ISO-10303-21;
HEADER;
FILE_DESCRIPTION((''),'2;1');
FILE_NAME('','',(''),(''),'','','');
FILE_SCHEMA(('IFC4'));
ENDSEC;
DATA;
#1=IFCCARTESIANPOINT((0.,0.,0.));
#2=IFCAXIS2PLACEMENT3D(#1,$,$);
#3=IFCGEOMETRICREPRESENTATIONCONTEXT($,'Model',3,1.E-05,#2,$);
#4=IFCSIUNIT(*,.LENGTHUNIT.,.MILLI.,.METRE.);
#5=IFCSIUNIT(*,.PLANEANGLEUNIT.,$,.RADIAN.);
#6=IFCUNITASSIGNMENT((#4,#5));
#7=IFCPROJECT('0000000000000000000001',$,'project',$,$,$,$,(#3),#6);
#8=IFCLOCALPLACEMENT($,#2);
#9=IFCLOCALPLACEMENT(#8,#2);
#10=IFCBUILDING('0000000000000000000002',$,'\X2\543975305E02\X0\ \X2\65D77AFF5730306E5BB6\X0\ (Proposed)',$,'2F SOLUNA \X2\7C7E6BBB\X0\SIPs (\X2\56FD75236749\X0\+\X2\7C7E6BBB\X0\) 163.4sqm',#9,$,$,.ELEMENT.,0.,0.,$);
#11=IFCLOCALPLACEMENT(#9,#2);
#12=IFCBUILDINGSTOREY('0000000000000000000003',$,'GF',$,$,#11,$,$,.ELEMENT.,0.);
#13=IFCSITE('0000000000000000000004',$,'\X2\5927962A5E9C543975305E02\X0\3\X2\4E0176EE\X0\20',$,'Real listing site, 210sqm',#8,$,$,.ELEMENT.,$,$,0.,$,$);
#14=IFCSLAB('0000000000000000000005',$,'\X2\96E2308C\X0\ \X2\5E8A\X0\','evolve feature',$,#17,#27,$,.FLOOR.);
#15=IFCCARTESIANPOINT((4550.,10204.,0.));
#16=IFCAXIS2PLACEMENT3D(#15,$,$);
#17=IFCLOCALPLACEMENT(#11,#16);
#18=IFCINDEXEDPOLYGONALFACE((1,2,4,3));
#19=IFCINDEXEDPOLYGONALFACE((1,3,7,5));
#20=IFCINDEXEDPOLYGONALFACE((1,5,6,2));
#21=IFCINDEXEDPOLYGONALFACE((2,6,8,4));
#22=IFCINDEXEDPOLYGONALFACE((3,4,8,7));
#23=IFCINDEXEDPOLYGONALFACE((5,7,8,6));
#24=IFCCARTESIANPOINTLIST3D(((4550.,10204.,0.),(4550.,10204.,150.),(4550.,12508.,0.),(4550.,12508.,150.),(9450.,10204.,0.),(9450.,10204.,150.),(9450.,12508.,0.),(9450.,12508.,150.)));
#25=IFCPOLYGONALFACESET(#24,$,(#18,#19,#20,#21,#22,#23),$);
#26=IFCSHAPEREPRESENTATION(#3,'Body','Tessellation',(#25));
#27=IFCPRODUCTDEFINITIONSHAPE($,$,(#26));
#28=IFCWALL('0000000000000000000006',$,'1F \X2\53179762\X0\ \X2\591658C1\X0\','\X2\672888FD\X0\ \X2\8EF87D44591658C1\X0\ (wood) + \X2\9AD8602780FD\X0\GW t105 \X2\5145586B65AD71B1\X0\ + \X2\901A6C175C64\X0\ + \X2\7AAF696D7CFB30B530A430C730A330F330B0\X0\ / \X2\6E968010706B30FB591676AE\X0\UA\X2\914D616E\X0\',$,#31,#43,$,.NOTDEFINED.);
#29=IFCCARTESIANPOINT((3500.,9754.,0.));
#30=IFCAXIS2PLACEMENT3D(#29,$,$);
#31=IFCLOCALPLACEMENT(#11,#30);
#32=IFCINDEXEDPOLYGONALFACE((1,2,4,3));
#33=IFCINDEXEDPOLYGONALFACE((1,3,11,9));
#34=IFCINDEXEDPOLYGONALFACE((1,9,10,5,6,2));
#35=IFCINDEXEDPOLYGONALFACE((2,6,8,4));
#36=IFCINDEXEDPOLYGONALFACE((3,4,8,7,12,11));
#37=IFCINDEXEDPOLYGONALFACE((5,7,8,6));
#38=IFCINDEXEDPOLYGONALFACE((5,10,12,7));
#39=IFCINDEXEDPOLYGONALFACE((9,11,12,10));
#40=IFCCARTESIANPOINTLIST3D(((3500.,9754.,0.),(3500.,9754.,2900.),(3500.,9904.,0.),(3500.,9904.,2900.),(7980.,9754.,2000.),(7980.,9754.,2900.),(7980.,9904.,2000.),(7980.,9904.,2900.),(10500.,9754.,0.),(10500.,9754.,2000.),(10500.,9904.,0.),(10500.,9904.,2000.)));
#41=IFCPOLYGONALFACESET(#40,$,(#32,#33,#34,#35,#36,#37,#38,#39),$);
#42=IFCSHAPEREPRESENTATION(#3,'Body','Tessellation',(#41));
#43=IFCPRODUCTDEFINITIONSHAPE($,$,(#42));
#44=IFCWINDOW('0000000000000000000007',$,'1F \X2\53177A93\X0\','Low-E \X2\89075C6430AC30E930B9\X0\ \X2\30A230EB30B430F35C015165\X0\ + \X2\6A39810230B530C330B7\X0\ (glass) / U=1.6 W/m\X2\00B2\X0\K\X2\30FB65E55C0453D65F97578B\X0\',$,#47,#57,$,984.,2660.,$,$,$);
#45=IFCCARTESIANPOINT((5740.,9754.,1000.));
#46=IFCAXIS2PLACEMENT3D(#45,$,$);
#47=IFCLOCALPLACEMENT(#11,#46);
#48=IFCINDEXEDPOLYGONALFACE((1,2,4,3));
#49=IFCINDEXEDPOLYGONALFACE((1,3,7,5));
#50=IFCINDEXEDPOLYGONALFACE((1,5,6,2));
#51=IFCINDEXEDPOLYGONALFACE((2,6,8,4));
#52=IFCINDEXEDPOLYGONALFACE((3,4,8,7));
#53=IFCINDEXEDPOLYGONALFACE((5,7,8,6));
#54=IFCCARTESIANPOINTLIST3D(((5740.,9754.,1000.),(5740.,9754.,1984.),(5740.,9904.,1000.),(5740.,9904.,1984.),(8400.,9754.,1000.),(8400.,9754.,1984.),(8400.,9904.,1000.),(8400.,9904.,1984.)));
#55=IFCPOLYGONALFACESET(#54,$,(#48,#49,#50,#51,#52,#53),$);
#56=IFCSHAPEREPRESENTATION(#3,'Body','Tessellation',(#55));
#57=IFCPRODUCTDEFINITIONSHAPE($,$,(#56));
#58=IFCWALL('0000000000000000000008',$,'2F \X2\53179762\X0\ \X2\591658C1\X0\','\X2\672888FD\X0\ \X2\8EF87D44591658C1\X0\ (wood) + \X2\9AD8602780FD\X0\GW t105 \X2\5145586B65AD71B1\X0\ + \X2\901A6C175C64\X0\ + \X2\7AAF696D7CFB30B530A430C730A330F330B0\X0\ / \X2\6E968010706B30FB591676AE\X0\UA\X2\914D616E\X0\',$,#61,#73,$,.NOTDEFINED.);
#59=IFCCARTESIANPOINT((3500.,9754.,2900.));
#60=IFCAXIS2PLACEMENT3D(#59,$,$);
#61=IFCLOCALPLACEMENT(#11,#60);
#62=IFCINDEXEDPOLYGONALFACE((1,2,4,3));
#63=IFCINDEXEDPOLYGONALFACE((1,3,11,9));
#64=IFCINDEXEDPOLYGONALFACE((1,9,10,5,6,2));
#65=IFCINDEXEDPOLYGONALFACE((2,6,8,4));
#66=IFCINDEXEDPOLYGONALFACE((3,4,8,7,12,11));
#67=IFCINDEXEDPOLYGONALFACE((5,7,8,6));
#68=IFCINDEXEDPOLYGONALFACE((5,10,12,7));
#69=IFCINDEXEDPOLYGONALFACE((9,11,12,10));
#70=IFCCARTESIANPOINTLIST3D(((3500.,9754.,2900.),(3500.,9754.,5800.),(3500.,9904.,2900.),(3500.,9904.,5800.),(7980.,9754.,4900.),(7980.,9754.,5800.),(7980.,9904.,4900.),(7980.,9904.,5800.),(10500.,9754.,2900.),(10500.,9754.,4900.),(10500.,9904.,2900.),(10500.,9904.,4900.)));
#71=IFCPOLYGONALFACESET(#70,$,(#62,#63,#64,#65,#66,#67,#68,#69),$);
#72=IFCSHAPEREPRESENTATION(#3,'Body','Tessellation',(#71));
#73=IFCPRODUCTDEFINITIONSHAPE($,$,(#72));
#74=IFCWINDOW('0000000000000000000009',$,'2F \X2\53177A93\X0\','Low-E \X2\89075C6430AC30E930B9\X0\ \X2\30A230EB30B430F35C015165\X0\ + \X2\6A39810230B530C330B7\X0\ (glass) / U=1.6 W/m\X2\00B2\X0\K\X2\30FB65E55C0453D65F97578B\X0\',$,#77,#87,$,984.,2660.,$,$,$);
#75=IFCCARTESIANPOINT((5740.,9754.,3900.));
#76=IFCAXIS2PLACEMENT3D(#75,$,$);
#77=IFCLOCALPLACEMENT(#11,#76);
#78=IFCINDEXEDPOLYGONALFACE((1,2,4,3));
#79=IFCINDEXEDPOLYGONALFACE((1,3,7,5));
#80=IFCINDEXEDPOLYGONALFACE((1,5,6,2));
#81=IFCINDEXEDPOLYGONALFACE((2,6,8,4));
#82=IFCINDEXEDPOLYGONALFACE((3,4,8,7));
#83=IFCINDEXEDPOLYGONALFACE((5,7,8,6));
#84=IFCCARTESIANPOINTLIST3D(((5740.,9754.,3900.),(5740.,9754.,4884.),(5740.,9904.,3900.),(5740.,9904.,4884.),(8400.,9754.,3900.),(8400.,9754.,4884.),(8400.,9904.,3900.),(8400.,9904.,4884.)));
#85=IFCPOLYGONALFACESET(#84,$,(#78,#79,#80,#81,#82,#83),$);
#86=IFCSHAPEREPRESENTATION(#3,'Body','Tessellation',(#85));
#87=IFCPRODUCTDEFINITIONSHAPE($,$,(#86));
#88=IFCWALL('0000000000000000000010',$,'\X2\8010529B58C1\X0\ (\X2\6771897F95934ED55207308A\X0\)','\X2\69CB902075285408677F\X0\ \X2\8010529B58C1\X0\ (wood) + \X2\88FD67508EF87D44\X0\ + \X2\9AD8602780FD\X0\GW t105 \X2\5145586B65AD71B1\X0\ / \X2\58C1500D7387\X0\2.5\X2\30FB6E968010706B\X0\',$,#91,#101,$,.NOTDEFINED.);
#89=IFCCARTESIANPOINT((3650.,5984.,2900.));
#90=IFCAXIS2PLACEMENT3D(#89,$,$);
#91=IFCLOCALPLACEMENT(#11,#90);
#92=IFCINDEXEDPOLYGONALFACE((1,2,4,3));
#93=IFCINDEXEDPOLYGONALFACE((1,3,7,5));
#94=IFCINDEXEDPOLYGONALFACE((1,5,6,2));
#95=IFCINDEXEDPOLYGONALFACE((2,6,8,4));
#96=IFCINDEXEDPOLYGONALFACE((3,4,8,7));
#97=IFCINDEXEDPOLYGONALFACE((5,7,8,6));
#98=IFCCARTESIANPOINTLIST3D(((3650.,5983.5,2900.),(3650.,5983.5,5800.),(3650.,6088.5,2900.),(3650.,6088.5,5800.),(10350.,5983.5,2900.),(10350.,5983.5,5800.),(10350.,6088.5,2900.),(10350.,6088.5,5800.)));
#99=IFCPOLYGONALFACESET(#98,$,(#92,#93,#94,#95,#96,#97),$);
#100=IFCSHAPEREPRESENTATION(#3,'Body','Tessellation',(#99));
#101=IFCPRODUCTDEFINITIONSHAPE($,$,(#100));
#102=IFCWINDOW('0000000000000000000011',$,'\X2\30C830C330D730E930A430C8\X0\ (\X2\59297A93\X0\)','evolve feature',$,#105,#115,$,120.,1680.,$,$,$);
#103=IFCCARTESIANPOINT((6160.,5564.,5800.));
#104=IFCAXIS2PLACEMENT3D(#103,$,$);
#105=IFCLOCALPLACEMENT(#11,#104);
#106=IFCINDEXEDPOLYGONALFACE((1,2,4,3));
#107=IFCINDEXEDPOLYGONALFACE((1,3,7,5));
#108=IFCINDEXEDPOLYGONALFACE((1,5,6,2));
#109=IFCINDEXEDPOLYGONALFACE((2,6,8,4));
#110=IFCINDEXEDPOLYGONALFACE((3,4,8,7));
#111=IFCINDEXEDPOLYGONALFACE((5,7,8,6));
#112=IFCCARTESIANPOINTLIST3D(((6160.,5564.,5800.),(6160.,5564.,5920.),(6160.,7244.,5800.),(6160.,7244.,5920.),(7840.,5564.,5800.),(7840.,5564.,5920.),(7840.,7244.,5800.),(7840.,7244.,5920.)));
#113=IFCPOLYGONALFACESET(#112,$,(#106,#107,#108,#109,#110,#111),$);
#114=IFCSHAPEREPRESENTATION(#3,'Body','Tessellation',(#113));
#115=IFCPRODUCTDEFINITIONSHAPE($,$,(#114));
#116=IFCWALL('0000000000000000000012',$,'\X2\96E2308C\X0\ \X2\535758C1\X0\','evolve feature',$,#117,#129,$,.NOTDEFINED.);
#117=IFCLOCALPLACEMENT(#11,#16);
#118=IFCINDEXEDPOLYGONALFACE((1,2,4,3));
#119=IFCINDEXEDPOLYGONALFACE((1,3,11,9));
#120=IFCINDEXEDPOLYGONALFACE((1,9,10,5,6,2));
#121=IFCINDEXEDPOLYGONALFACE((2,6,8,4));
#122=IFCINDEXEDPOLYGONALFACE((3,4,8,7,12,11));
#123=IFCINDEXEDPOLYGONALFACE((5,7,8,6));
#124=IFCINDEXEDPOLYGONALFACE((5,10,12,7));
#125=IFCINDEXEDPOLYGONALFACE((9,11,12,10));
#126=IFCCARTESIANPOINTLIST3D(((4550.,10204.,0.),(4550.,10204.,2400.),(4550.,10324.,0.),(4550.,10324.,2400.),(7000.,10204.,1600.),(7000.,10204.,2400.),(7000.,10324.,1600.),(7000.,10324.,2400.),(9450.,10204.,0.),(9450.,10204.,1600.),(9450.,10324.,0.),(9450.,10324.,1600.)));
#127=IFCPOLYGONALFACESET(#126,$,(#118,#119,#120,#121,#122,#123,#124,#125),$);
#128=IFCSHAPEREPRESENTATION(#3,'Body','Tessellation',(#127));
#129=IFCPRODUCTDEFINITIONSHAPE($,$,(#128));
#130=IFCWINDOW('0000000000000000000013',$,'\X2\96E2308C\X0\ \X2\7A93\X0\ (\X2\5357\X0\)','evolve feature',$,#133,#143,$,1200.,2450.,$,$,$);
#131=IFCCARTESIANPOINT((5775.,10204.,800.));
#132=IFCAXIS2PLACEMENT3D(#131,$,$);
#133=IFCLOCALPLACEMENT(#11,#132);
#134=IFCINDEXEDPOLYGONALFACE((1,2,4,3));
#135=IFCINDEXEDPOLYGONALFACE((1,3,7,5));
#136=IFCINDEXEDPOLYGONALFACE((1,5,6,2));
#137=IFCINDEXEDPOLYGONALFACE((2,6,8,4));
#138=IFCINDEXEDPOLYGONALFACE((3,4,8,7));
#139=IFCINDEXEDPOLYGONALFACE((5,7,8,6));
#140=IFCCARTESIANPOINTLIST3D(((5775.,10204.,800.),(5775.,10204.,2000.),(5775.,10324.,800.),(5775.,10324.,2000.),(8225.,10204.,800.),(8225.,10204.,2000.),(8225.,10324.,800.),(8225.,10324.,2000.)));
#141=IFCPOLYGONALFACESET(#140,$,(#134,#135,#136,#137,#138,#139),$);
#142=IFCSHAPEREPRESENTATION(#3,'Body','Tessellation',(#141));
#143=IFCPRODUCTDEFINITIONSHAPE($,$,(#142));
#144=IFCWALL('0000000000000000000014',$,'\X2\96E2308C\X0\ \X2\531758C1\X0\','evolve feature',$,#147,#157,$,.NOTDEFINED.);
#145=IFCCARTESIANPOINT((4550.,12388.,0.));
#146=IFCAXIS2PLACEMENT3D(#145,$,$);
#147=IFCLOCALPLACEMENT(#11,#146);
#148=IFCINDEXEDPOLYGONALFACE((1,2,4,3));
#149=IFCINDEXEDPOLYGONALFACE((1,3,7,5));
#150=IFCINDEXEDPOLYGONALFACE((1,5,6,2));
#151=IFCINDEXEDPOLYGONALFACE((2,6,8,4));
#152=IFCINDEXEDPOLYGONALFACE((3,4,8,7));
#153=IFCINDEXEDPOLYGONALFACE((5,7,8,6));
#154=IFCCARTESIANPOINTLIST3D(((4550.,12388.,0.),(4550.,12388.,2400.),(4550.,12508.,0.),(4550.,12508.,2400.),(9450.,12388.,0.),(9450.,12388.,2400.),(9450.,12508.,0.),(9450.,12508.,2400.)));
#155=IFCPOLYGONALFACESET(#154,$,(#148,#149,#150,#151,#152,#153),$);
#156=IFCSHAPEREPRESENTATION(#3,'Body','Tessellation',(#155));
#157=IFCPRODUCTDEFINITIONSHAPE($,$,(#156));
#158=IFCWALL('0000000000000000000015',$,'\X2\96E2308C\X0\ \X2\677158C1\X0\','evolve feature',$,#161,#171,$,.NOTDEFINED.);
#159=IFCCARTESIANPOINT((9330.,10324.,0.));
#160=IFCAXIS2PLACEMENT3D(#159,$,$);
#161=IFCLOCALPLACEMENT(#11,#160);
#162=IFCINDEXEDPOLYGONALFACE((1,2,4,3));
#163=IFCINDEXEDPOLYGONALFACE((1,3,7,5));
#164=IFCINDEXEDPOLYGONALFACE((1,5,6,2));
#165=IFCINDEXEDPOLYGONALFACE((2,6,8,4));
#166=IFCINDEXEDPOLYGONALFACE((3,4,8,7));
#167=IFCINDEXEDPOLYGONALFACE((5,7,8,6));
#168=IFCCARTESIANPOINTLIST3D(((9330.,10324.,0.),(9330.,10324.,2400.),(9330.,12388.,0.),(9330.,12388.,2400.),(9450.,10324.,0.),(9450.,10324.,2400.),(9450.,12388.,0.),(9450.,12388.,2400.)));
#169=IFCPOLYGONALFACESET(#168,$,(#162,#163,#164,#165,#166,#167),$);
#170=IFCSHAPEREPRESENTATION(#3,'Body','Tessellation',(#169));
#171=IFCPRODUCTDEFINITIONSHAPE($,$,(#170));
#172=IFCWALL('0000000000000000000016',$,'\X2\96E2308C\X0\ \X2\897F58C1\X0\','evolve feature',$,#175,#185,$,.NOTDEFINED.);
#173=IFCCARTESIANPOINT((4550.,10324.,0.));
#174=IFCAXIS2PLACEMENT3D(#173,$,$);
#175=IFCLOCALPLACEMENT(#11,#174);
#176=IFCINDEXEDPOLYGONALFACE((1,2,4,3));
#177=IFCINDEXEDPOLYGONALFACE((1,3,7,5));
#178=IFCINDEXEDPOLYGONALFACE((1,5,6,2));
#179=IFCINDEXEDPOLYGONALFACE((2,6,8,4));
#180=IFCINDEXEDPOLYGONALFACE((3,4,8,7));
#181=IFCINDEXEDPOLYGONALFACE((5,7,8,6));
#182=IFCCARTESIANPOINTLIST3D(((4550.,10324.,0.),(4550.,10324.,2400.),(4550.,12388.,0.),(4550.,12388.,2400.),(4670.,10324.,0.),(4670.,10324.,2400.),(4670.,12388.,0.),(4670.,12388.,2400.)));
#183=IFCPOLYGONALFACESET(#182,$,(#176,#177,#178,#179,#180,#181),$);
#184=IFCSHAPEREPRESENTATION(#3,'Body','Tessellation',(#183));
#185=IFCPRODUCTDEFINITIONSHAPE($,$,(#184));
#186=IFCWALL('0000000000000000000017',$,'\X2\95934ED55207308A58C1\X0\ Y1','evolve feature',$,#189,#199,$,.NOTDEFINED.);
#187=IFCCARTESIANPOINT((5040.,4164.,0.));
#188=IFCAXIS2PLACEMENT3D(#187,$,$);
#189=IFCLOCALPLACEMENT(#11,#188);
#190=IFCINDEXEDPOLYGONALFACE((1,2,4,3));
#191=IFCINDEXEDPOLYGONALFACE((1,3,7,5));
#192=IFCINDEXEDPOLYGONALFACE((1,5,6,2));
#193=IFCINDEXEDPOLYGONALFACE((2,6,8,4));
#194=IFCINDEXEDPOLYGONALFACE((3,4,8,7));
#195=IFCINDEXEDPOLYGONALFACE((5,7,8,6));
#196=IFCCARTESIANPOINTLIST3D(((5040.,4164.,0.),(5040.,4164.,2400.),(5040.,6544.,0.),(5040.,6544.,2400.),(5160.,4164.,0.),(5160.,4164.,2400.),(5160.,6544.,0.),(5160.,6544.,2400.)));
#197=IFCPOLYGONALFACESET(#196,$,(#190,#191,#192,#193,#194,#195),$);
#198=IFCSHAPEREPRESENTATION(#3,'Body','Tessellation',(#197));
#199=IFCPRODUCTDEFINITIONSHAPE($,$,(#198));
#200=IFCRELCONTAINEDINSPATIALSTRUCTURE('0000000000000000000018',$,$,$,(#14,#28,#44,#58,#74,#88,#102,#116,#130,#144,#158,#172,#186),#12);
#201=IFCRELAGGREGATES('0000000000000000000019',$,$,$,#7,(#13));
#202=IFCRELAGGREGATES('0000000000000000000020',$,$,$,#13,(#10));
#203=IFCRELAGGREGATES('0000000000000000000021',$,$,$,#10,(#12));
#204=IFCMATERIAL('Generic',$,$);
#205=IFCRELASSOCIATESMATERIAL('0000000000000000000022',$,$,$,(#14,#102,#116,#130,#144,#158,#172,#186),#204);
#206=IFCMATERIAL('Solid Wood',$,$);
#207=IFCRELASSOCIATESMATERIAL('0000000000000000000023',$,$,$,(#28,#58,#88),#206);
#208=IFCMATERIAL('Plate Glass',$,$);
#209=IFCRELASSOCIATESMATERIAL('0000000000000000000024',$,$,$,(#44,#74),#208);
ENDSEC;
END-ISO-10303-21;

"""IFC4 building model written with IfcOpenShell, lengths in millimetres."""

from ifc_helpers import new_model, si_unit, frame, frame_2d, origin, place, context, project, spatial, rectangle, extrude, material, element, fill, save


model = new_model("IFC4")

# Units and contexts
model_context = context("Model", 3, precision=1e-05, world=origin())
ifc_project = project(units=[si_unit("LENGTHUNIT", "METRE", prefix="MILLI"), si_unit("PLANEANGLEUNIT", "RADIAN")], contexts=[model_context])

# Site, building, storey
site_placement = place(None, origin())
site = spatial("IfcSite", under=ifc_project, at=site_placement, Name="大阪府吹田市3丁目20", ObjectType="Real listing site, 210sqm", CompositionType="ELEMENT", RefElevation=0.0)
building_placement = place(site_placement, origin())
building = spatial("IfcBuilding", under=site, at=building_placement, Name="吹田市 旗竿地の家 (Proposed)", ObjectType="2F SOLUNA 籾殻SIPs (国産杉+籾殻) 163.4sqm", CompositionType="ELEMENT", ElevationOfRefHeight=0.0, ElevationOfTerrain=0.0)
storey_placement = place(building_placement, origin())
storey = spatial("IfcBuildingStorey", under=building, at=storey_placement, Name="GF", CompositionType="ELEMENT", Elevation=0.0)

# Slab
ifc_material_1 = material(Name="Generic")
slab_placement = place(storey_placement, frame((4550.0, 10204.0, 0.0)))
element("IfcSlab", 1, at=slab_placement, inside=storey, material=ifc_material_1, Name="離れ 床", Description="evolve feature", PredefinedType="FLOOR", context=model_context, shape_type="SweptSolid", body=[
    extrude(rectangle(XDim=4900.0, YDim=2304.0, at=frame_2d((2450.0, 1152.0))), frame((4550.0, 10204.0, 0.0)), (0.0, 0.0, 1.0), 150.0),
])

# Wall, opening, window
ifc_material_2 = material(Name="Solid Wood")
wall_1_placement = place(storey_placement, frame((3500.0, 9754.0, 0.0)))
wall_1 = element("IfcWall", 2, at=wall_1_placement, inside=storey, material=ifc_material_2, Name="1F 北面 外壁", Description="木製 軸組外壁 (wood) + 高性能GW t105 充填断熱 + 通気層 + 窯業系サイディング / 準耐火・外皮UA配慮", PredefinedType="NOTDEFINED", context=model_context, shape_type="SweptSolid", body=[
    extrude(rectangle(XDim=7000.0, YDim=150.0, at=frame_2d((3500.0, 75.0))), frame((3500.0, 9754.0, 0.0)), (0.0, 0.0, 1.0), 2900.0),
])
opening_1_placement = place(storey_placement, frame((5740.0, 9754.0, 1000.0)))
opening_1 = element("IfcOpeningElement", 3, at=opening_1_placement, cuts=wall_1, PredefinedType="NOTDEFINED", context=model_context, shape_type="SweptSolid", body=[
    extrude(rectangle(XDim=2660.0, YDim=150.0, at=frame_2d((1330.0, 75.0))), frame((5740.0, 9754.0, 1000.0)), (0.0, 0.0, 1.0), 984.0),
])
ifc_material_3 = material(Name="Plate Glass")
window_1_placement = place(storey_placement, frame((5740.0, 9754.0, 1000.0)))
window_1 = element("IfcWindow", 4, at=window_1_placement, inside=storey, material=ifc_material_3, Name="1F 北窓", Description="Low-E 複層ガラス アルゴン封入 + 樹脂サッシ (glass) / U=1.6 W/m²K・日射取得型", OverallHeight=984.0, OverallWidth=2660.0, context=model_context, shape_type="SweptSolid", body=[
    extrude(rectangle(XDim=2660.0, YDim=150.0, at=frame_2d((1330.0, 75.0))), frame((5740.0, 9754.0, 1000.0)), (0.0, 0.0, 1.0), 984.0),
])
fill(opening_1, window_1)

# Wall, opening, window
wall_2_placement = place(storey_placement, frame((3500.0, 9754.0, 2900.0)))
wall_2 = element("IfcWall", 5, at=wall_2_placement, inside=storey, material=ifc_material_2, Name="2F 北面 外壁", Description="木製 軸組外壁 (wood) + 高性能GW t105 充填断熱 + 通気層 + 窯業系サイディング / 準耐火・外皮UA配慮", PredefinedType="NOTDEFINED", context=model_context, shape_type="SweptSolid", body=[
    extrude(rectangle(XDim=7000.0, YDim=150.0, at=frame_2d((3500.0, 75.0))), frame((3500.0, 9754.0, 2900.0)), (0.0, 0.0, 1.0), 2900.0),
])
opening_2_placement = place(storey_placement, frame((5740.0, 9754.0, 3900.0)))
opening_2 = element("IfcOpeningElement", 6, at=opening_2_placement, cuts=wall_2, PredefinedType="NOTDEFINED", context=model_context, shape_type="SweptSolid", body=[
    extrude(rectangle(XDim=2660.0, YDim=150.0, at=frame_2d((1330.0, 75.0))), frame((5740.0, 9754.0, 3900.0)), (0.0, 0.0, 1.0), 984.0),
])
window_2_placement = place(storey_placement, frame((5740.0, 9754.0, 3900.0)))
window_2 = element("IfcWindow", 7, at=window_2_placement, inside=storey, material=ifc_material_3, Name="2F 北窓", Description="Low-E 複層ガラス アルゴン封入 + 樹脂サッシ (glass) / U=1.6 W/m²K・日射取得型", OverallHeight=984.0, OverallWidth=2660.0, context=model_context, shape_type="SweptSolid", body=[
    extrude(rectangle(XDim=2660.0, YDim=150.0, at=frame_2d((1330.0, 75.0))), frame((5740.0, 9754.0, 3900.0)), (0.0, 0.0, 1.0), 984.0),
])
fill(opening_2, window_2)

# Wall
wall_3_placement = place(storey_placement, frame((3650.0, 5984.0, 2900.0)))
element("IfcWall", 8, at=wall_3_placement, inside=storey, material=ifc_material_2, Name="耐力壁 (東西間仕切り)", Description="構造用合板 耐力壁 (wood) + 製材軸組 + 高性能GW t105 充填断熱 / 壁倍率2.5・準耐火", PredefinedType="NOTDEFINED", context=model_context, shape_type="SweptSolid", body=[
    extrude(rectangle(XDim=6700.0, YDim=105.0, at=frame_2d((3350.0, 52.0))), frame((3650.0, 5984.0, 2900.0)), (0.0, 0.0, 1.0), 2900.0),
])

# Window
window_3_placement = place(storey_placement, frame((6160.0, 5564.0, 5800.0)))
element("IfcWindow", 9, at=window_3_placement, inside=storey, material=ifc_material_1, Name="トップライト (天窓)", Description="evolve feature", OverallHeight=120.0, OverallWidth=1680.0, context=model_context, shape_type="SweptSolid", body=[
    extrude(rectangle(XDim=1680.0, YDim=1680.0, at=frame_2d((840.0, 840.0))), frame((6160.0, 5564.0, 5800.0)), (0.0, 0.0, 1.0), 120.0),
])

# Wall, opening, window
wall_4_placement = place(storey_placement, frame((4550.0, 10204.0, 0.0)))
wall_4 = element("IfcWall", 10, at=wall_4_placement, inside=storey, material=ifc_material_1, Name="離れ 南壁", Description="evolve feature", PredefinedType="NOTDEFINED", context=model_context, shape_type="SweptSolid", body=[
    extrude(rectangle(XDim=4900.0, YDim=120.0, at=frame_2d((2450.0, 60.0))), frame((4550.0, 10204.0, 0.0)), (0.0, 0.0, 1.0), 2400.0),
])
opening_3_placement = place(storey_placement, frame((5775.0, 10204.0, 800.0)))
opening_3 = element("IfcOpeningElement", 11, at=opening_3_placement, cuts=wall_4, PredefinedType="NOTDEFINED", context=model_context, shape_type="SweptSolid", body=[
    extrude(rectangle(XDim=2450.0, YDim=120.0, at=frame_2d((1225.0, 60.0))), frame((5775.0, 10204.0, 800.0)), (0.0, 0.0, 1.0), 1200.0),
])
window_4_placement = place(storey_placement, frame((5775.0, 10204.0, 800.0)))
window_4 = element("IfcWindow", 12, at=window_4_placement, inside=storey, material=ifc_material_1, Name="離れ 窓 (南)", Description="evolve feature", OverallHeight=1200.0, OverallWidth=2450.0, context=model_context, shape_type="SweptSolid", body=[
    extrude(rectangle(XDim=2450.0, YDim=120.0, at=frame_2d((1225.0, 60.0))), frame((5775.0, 10204.0, 800.0)), (0.0, 0.0, 1.0), 1200.0),
])
fill(opening_3, window_4)

# Walls
wall_5_placement = place(storey_placement, frame((4550.0, 12388.0, 0.0)))
element("IfcWall", 13, at=wall_5_placement, inside=storey, material=ifc_material_1, Name="離れ 北壁", Description="evolve feature", PredefinedType="NOTDEFINED", context=model_context, shape_type="SweptSolid", body=[
    extrude(rectangle(XDim=4900.0, YDim=120.0, at=frame_2d((2450.0, 60.0))), frame((4550.0, 12388.0, 0.0)), (0.0, 0.0, 1.0), 2400.0),
])
wall_6_placement = place(storey_placement, frame((9330.0, 10324.0, 0.0)))
element("IfcWall", 14, at=wall_6_placement, inside=storey, material=ifc_material_1, Name="離れ 東壁", Description="evolve feature", PredefinedType="NOTDEFINED", context=model_context, shape_type="SweptSolid", body=[
    extrude(rectangle(XDim=120.0, YDim=2064.0, at=frame_2d((60.0, 1032.0))), frame((9330.0, 10324.0, 0.0)), (0.0, 0.0, 1.0), 2400.0),
])
wall_7_placement = place(storey_placement, frame((4550.0, 10324.0, 0.0)))
element("IfcWall", 15, at=wall_7_placement, inside=storey, material=ifc_material_1, Name="離れ 西壁", Description="evolve feature", PredefinedType="NOTDEFINED", context=model_context, shape_type="SweptSolid", body=[
    extrude(rectangle(XDim=120.0, YDim=2064.0, at=frame_2d((60.0, 1032.0))), frame((4550.0, 10324.0, 0.0)), (0.0, 0.0, 1.0), 2400.0),
])
wall_8_placement = place(storey_placement, frame((5040.0, 4164.0, 0.0)))
element("IfcWall", 16, at=wall_8_placement, inside=storey, material=ifc_material_1, Name="間仕切り壁 Y1", Description="evolve feature", PredefinedType="NOTDEFINED", context=model_context, shape_type="SweptSolid", body=[
    extrude(rectangle(XDim=120.0, YDim=2380.0, at=frame_2d((60.0, 1190.0))), frame((5040.0, 4164.0, 0.0)), (0.0, 0.0, 1.0), 2400.0),
])

save(model, "model.ifc")
